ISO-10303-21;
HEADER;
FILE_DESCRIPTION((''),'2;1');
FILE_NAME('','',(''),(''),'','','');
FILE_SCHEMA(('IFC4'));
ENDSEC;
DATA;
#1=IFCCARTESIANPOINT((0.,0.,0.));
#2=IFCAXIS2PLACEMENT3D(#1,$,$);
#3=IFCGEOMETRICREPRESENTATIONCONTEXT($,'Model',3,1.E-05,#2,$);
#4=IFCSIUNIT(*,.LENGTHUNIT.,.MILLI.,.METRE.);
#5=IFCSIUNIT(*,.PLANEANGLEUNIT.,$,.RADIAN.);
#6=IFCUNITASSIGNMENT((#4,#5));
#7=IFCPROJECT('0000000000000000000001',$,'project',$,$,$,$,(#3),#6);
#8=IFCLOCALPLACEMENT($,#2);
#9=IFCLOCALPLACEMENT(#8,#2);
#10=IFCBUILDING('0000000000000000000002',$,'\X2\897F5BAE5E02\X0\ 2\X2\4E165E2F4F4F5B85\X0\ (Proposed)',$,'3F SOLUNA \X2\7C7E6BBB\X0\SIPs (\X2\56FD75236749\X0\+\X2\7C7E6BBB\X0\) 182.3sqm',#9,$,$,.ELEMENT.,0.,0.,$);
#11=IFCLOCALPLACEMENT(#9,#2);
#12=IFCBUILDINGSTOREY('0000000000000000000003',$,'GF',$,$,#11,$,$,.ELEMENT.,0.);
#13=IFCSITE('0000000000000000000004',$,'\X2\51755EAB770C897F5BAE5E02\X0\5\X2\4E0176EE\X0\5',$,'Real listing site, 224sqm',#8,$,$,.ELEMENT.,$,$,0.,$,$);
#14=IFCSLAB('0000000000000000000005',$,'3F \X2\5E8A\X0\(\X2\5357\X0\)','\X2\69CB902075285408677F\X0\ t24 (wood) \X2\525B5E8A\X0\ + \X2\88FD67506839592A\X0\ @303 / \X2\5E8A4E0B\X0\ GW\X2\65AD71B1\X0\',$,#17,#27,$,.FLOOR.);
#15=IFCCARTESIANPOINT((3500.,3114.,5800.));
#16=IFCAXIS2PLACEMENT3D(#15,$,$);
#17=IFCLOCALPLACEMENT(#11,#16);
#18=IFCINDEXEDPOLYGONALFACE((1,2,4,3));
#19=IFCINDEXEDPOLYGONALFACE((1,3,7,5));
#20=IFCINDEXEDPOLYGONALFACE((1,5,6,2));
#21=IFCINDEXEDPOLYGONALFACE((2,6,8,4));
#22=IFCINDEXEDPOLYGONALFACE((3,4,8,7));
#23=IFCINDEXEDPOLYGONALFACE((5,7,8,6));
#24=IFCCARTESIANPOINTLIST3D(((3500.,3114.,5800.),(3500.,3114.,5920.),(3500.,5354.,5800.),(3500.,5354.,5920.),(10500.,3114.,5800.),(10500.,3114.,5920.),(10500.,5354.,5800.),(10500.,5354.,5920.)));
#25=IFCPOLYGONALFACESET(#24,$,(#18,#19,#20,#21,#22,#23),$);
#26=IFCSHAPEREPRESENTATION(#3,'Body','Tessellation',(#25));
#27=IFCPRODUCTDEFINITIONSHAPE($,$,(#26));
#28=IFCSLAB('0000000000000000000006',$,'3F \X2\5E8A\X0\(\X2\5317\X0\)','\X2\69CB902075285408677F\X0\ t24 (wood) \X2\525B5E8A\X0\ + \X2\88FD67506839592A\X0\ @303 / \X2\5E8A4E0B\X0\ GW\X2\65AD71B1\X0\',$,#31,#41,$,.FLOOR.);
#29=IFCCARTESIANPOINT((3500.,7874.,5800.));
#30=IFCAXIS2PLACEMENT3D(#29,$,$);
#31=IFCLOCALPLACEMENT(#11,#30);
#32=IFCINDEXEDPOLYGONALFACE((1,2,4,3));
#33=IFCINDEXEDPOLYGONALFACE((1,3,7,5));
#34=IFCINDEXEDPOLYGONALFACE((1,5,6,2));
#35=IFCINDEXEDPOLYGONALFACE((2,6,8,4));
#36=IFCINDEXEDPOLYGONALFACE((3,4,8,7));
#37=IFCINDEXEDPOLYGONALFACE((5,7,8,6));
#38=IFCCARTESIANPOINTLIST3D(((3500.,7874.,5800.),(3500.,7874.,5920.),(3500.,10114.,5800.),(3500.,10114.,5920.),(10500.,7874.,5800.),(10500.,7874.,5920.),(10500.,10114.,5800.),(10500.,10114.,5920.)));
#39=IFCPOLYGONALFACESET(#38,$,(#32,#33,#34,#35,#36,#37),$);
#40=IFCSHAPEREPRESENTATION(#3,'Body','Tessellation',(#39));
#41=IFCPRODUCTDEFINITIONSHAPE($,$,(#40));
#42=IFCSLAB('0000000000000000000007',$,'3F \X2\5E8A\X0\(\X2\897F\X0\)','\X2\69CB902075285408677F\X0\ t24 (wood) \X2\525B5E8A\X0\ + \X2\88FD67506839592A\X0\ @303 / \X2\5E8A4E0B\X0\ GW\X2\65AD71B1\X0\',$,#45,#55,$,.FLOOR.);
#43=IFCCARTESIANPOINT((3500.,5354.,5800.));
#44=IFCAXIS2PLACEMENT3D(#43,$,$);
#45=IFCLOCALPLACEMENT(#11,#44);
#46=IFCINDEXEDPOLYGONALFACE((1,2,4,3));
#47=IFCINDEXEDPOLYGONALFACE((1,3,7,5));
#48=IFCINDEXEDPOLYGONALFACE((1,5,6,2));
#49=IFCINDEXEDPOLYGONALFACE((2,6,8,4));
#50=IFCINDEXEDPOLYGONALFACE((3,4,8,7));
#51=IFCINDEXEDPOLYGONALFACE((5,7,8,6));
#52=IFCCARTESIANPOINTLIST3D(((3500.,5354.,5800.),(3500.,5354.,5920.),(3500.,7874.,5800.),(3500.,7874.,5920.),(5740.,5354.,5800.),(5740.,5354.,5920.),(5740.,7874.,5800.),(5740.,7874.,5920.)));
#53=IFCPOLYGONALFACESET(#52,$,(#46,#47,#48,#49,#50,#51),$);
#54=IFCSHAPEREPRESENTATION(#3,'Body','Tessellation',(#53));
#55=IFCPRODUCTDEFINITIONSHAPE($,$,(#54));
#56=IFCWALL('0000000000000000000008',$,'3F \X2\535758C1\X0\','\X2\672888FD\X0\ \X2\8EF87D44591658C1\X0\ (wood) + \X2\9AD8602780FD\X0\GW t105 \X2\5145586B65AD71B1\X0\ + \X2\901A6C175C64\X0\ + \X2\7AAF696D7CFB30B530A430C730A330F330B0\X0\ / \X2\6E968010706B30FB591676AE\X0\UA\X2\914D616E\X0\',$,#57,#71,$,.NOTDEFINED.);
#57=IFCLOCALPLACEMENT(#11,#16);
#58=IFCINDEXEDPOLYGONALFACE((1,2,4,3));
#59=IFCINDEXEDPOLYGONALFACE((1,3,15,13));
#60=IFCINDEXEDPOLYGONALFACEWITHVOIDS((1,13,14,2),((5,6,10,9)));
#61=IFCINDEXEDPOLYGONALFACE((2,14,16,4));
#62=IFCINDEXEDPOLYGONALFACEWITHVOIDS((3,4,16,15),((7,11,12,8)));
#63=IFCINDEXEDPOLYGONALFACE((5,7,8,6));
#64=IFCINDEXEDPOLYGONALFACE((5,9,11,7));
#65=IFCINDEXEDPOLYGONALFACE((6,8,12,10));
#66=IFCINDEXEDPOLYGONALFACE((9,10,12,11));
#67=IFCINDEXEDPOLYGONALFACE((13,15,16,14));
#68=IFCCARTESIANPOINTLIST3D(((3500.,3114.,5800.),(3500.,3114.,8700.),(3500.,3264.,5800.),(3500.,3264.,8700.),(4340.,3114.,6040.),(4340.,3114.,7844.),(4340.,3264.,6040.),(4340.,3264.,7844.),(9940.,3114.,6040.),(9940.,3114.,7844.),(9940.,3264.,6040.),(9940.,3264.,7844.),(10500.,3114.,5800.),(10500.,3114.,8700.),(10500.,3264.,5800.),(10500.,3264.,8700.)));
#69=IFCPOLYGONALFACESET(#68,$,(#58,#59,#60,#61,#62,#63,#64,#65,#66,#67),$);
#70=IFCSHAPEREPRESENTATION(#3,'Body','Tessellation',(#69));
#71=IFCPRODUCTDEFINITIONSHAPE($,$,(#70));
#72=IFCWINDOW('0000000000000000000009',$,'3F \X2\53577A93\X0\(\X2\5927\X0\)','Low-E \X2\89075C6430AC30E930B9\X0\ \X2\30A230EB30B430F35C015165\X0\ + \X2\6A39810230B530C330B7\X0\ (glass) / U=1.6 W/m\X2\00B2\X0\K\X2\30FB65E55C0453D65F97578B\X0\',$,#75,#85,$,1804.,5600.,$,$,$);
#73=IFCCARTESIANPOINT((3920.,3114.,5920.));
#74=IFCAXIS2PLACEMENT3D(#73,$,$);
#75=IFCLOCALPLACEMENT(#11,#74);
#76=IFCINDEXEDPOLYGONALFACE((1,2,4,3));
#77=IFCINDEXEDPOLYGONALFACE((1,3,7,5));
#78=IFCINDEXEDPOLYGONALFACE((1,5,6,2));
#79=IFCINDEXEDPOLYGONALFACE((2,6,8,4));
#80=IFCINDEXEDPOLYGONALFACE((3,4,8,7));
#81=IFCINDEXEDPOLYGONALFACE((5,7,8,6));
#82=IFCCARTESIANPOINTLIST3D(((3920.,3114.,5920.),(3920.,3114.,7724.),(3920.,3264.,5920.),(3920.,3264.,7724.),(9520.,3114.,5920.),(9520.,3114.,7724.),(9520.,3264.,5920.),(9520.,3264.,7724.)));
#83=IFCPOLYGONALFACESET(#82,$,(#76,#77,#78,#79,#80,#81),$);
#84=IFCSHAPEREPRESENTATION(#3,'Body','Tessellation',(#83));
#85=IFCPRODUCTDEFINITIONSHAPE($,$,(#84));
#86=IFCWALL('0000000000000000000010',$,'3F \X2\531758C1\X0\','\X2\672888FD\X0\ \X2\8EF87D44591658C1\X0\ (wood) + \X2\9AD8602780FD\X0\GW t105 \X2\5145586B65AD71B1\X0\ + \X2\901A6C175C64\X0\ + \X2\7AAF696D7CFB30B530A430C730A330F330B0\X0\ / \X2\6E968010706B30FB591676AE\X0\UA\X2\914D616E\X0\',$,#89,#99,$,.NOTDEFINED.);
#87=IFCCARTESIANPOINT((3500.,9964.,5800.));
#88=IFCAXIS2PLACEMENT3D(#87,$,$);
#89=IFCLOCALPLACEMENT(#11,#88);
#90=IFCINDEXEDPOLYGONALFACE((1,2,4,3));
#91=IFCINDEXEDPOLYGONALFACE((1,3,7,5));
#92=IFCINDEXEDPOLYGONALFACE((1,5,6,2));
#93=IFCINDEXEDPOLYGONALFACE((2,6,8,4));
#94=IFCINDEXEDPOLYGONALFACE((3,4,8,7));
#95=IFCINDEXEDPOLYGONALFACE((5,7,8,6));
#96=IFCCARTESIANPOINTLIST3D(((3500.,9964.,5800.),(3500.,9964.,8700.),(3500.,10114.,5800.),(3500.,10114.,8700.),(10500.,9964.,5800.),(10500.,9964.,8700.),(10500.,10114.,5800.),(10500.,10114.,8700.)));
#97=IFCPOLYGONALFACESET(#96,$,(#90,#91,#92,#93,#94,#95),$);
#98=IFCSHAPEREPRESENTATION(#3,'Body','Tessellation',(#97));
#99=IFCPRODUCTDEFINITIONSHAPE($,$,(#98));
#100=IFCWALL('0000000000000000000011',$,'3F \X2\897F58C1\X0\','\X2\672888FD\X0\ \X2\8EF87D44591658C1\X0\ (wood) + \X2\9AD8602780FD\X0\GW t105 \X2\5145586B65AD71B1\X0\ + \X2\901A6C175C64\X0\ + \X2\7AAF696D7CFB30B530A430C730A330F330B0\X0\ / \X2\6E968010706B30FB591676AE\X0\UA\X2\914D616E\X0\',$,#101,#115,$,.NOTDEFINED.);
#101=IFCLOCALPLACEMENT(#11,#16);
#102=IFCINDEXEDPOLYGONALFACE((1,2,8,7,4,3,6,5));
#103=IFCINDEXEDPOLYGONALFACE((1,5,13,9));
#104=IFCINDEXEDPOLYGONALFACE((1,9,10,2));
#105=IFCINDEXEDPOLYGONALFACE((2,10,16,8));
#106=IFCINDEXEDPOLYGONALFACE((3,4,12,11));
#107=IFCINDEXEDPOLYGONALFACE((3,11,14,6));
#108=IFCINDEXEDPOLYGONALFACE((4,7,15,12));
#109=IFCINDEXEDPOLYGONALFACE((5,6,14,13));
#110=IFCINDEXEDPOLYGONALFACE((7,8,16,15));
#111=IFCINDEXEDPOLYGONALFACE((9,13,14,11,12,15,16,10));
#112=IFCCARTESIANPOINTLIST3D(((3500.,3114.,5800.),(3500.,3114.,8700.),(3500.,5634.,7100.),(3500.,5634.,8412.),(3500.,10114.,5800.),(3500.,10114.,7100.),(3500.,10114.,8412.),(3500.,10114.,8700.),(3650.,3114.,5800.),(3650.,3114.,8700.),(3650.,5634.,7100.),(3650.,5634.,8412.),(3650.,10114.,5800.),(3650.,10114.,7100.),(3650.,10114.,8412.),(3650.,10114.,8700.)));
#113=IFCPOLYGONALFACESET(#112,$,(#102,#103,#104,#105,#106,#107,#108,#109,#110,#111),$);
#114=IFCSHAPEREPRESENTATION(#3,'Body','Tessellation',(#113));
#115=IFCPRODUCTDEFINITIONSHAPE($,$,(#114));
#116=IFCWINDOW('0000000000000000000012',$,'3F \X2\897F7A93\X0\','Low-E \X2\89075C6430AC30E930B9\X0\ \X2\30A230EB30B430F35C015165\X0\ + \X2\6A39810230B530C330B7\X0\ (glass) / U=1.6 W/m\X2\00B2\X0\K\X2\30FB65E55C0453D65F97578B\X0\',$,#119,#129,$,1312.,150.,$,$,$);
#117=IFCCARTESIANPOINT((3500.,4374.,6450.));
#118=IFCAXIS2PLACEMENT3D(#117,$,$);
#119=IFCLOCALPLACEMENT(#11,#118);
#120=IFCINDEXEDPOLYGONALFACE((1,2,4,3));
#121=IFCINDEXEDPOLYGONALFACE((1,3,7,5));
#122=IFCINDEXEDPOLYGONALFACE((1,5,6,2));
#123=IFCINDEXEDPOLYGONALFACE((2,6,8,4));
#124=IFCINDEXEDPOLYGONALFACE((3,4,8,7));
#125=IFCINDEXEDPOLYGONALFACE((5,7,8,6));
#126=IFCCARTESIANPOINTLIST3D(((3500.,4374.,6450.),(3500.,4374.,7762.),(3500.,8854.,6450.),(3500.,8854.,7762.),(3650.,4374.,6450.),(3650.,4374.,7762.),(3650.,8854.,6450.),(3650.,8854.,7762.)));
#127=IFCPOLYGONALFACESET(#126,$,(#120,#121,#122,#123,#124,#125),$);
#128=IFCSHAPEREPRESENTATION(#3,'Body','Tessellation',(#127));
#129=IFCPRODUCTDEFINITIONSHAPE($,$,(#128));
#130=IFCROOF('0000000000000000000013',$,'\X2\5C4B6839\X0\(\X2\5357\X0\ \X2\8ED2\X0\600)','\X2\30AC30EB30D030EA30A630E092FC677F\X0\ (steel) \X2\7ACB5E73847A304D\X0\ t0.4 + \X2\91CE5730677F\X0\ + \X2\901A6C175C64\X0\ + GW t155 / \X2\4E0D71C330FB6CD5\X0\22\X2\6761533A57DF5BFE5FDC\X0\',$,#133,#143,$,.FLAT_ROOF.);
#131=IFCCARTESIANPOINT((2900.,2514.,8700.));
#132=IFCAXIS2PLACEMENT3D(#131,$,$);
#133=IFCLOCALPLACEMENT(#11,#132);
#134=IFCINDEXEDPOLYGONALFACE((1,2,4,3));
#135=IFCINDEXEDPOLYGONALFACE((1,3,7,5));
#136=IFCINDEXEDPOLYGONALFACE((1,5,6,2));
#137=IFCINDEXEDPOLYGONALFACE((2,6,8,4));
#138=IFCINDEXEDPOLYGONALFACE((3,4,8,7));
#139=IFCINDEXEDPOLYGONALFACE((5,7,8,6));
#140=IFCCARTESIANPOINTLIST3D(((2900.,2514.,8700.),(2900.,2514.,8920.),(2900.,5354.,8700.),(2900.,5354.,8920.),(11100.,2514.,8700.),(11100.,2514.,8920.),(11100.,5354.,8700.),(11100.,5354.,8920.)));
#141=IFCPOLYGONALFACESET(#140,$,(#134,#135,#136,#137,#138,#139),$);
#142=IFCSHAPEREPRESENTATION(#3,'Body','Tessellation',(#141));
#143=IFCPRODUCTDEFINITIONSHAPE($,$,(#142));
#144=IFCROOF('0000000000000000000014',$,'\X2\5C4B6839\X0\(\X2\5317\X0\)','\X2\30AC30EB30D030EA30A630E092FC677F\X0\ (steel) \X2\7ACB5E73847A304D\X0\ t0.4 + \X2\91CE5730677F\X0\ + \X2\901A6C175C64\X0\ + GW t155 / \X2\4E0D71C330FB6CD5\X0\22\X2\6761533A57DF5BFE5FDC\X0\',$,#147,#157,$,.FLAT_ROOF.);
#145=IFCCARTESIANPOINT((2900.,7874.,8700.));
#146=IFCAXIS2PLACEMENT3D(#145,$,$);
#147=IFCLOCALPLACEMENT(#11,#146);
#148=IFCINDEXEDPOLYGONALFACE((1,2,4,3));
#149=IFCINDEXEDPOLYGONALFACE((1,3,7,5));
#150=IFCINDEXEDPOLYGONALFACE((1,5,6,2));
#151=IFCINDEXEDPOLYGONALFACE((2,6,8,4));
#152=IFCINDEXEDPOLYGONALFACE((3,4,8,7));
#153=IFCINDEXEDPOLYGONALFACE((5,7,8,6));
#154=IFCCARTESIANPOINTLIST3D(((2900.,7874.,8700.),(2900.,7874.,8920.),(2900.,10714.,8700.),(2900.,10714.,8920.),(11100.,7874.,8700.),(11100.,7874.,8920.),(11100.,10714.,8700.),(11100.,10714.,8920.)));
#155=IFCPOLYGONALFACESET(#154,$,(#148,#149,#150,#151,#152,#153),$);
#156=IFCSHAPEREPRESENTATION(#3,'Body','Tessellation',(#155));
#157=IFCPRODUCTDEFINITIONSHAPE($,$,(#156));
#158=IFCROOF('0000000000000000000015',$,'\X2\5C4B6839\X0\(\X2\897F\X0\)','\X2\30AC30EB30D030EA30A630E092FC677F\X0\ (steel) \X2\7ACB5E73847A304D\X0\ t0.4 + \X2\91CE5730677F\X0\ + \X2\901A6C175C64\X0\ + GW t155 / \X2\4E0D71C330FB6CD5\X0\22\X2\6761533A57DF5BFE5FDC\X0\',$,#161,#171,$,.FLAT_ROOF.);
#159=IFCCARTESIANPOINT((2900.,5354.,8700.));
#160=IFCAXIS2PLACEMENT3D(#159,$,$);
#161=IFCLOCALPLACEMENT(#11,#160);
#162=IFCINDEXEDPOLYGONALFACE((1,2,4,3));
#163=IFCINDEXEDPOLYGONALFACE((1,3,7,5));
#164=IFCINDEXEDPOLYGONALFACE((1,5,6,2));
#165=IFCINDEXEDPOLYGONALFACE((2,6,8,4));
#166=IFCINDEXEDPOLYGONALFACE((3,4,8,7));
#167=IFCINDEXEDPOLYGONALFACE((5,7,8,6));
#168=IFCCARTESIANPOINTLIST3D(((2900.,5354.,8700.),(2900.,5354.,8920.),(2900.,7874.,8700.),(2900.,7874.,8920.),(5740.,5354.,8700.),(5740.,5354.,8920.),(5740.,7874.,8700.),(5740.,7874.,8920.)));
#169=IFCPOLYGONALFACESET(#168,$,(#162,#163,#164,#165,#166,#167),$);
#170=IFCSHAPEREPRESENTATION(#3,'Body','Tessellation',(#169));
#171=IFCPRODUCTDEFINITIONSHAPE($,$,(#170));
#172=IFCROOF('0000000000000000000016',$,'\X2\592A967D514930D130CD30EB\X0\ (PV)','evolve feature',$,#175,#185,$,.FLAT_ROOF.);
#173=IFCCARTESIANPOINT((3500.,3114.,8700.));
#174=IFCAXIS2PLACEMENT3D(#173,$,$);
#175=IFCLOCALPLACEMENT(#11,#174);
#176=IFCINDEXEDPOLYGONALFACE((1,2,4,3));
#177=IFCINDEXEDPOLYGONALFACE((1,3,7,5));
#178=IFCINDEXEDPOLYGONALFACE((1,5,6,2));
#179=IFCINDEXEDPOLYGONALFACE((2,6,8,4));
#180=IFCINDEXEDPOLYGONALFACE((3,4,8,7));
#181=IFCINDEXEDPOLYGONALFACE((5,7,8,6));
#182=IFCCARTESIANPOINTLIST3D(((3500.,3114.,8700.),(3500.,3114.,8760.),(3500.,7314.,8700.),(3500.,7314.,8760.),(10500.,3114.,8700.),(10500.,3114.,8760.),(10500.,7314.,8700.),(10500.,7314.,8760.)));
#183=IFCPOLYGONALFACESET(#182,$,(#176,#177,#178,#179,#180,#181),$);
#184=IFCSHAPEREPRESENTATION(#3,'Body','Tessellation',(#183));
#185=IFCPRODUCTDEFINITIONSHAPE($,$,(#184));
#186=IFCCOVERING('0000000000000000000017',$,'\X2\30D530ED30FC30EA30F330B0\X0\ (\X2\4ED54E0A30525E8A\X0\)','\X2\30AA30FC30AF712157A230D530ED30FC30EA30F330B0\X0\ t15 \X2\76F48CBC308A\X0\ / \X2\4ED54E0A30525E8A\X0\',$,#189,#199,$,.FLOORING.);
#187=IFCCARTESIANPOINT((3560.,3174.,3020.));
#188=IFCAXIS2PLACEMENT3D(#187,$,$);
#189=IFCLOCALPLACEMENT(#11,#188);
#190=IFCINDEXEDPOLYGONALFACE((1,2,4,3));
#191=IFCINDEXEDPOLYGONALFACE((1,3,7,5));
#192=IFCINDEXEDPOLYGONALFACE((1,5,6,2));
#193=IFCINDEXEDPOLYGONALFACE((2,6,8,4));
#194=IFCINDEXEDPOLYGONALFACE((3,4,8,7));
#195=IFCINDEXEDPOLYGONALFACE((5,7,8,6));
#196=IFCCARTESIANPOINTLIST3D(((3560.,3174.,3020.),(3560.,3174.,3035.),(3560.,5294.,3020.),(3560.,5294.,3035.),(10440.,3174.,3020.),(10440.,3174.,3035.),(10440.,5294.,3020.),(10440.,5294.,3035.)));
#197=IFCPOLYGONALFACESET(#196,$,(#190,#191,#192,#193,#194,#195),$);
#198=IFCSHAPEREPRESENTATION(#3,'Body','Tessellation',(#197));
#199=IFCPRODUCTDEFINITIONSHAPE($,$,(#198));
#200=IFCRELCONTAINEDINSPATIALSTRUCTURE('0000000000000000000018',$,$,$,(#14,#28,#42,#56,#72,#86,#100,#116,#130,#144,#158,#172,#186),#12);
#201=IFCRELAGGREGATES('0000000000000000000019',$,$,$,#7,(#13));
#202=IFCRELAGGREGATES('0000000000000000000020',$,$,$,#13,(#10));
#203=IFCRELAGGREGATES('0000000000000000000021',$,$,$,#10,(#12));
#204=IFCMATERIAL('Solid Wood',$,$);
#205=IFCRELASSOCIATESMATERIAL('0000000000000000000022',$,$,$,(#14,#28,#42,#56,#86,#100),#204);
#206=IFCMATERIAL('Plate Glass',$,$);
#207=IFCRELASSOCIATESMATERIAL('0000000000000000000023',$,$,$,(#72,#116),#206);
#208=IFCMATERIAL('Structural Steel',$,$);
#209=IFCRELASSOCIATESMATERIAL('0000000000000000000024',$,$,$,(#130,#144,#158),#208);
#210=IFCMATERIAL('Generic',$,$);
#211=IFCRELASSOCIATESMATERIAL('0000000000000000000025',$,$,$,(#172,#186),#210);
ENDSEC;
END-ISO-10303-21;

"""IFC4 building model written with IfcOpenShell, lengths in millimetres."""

from ifc_helpers import new_model, si_unit, frame, frame_2d, origin, place, context, project, spatial, rectangle, extrude, material, element, fill, save


model = new_model("IFC4")

# Units and contexts
model_context = context("Model", 3, precision=1e-05, world=origin())
ifc_project = project(units=[si_unit("LENGTHUNIT", "METRE", prefix="MILLI"), si_unit("PLANEANGLEUNIT", "RADIAN")], contexts=[model_context])

# Site, building, storey
site_placement = place(None, origin())
site = spatial("IfcSite", under=ifc_project, at=site_placement, Name="兵庫県西宮市5丁目5", ObjectType="Real listing site, 224sqm", CompositionType="ELEMENT", RefElevation=0.0)
building_placement = place(site_placement, origin())
building = spatial("IfcBuilding", under=site, at=building_placement, Name="西宮市 2世帯住宅 (Proposed)", ObjectType="3F SOLUNA 籾殻SIPs (国産杉+籾殻) 182.3sqm", CompositionType="ELEMENT", ElevationOfRefHeight=0.0, ElevationOfTerrain=0.0)
storey_placement = place(building_placement, origin())
storey = spatial("IfcBuildingStorey", under=building, at=storey_placement, Name="GF", CompositionType="ELEMENT", Elevation=0.0)

# Slabs
ifc_material_1 = material(Name="Solid Wood")
slab_1_placement = place(storey_placement, frame((3500.0, 3114.0, 5800.0)))
element("IfcSlab", 1, at=slab_1_placement, inside=storey, material=ifc_material_1, Name="3F 床(南)", Description="構造用合板 t24 (wood) 剛床 + 製材根太 @303 / 床下 GW断熱", PredefinedType="FLOOR", context=model_context, shape_type="SweptSolid", body=[
    extrude(rectangle(XDim=7000.0, YDim=2240.0, at=frame_2d((3500.0, 1120.0))), frame((3500.0, 3114.0, 5800.0)), (0.0, 0.0, 1.0), 120.0),
])
slab_2_placement = place(storey_placement, frame((3500.0, 7874.0, 5800.0)))
element("IfcSlab", 2, at=slab_2_placement, inside=storey, material=ifc_material_1, Name="3F 床(北)", Description="構造用合板 t24 (wood) 剛床 + 製材根太 @303 / 床下 GW断熱", PredefinedType="FLOOR", context=model_context, shape_type="SweptSolid", body=[
    extrude(rectangle(XDim=7000.0, YDim=2240.0, at=frame_2d((3500.0, 1120.0))), frame((3500.0, 7874.0, 5800.0)), (0.0, 0.0, 1.0), 120.0),
])
slab_3_placement = place(storey_placement, frame((3500.0, 5354.0, 5800.0)))
element("IfcSlab", 3, at=slab_3_placement, inside=storey, material=ifc_material_1, Name="3F 床(西)", Description="構造用合板 t24 (wood) 剛床 + 製材根太 @303 / 床下 GW断熱", PredefinedType="FLOOR", context=model_context, shape_type="SweptSolid", body=[
    extrude(rectangle(XDim=2240.0, YDim=2520.0, at=frame_2d((1120.0, 1260.0))), frame((3500.0, 5354.0, 5800.0)), (0.0, 0.0, 1.0), 120.0),
])

# Wall, opening, window
wall_1_placement = place(storey_placement, frame((3500.0, 3114.0, 5800.0)))
wall_1 = element("IfcWall", 4, at=wall_1_placement, inside=storey, material=ifc_material_1, Name="3F 南壁", Description="木製 軸組外壁 (wood) + 高性能GW t105 充填断熱 + 通気層 + 窯業系サイディング / 準耐火・外皮UA配慮", PredefinedType="NOTDEFINED", context=model_context, shape_type="SweptSolid", body=[
    extrude(rectangle(XDim=7000.0, YDim=150.0, at=frame_2d((3500.0, 75.0))), frame((3500.0, 3114.0, 5800.0)), (0.0, 0.0, 1.0), 2900.0),
])
opening_1_placement = place(storey_placement, frame((3920.0, 3114.0, 5920.0)))
opening_1 = element("IfcOpeningElement", 5, at=opening_1_placement, cuts=wall_1, PredefinedType="NOTDEFINED", context=model_context, shape_type="SweptSolid", body=[
    extrude(rectangle(XDim=5600.0, YDim=150.0, at=frame_2d((2800.0, 75.0))), frame((3920.0, 3114.0, 5920.0)), (0.0, 0.0, 1.0), 1804.0),
])
ifc_material_2 = material(Name="Plate Glass")
window_1_placement = place(storey_placement, frame((3920.0, 3114.0, 5920.0)))
window_1 = element("IfcWindow", 6, at=window_1_placement, inside=storey, material=ifc_material_2, Name="3F 南窓(大)", Description="Low-E 複層ガラス アルゴン封入 + 樹脂サッシ (glass) / U=1.6 W/m²K・日射取得型", OverallHeight=1804.0, OverallWidth=5600.0, context=model_context, shape_type="SweptSolid", body=[
    extrude(rectangle(XDim=5600.0, YDim=150.0, at=frame_2d((2800.0, 75.0))), frame((3920.0, 3114.0, 5920.0)), (0.0, 0.0, 1.0), 1804.0),
])
fill(opening_1, window_1)

# Wall
wall_2_placement = place(storey_placement, frame((3500.0, 9964.0, 5800.0)))
element("IfcWall", 7, at=wall_2_placement, inside=storey, material=ifc_material_1, Name="3F 北壁", Description="木製 軸組外壁 (wood) + 高性能GW t105 充填断熱 + 通気層 + 窯業系サイディング / 準耐火・外皮UA配慮", PredefinedType="NOTDEFINED", context=model_context, shape_type="SweptSolid", body=[
    extrude(rectangle(XDim=7000.0, YDim=150.0, at=frame_2d((3500.0, 75.0))), frame((3500.0, 9964.0, 5800.0)), (0.0, 0.0, 1.0), 2900.0),
])

# Wall, opening, window
wall_3_placement = place(storey_placement, frame((3500.0, 3114.0, 5800.0)))
wall_3 = element("IfcWall", 8, at=wall_3_placement, inside=storey, material=ifc_material_1, Name="3F 西壁", Description="木製 軸組外壁 (wood) + 高性能GW t105 充填断熱 + 通気層 + 窯業系サイディング / 準耐火・外皮UA配慮", PredefinedType="NOTDEFINED", context=model_context, shape_type="SweptSolid", body=[
    extrude(rectangle(XDim=150.0, YDim=7000.0, at=frame_2d((75.0, 3500.0))), frame((3500.0, 3114.0, 5800.0)), (0.0, 0.0, 1.0), 2900.0),
])
opening_2_placement = place(storey_placement, frame((3500.0, 4374.0, 6450.0)))
opening_2 = element("IfcOpeningElement", 9, at=opening_2_placement, cuts=wall_3, PredefinedType="NOTDEFINED", context=model_context, shape_type="SweptSolid", body=[
    extrude(rectangle(XDim=150.0, YDim=4480.0, at=frame_2d((75.0, 2240.0))), frame((3500.0, 4374.0, 6450.0)), (0.0, 0.0, 1.0), 1312.0),
])
window_2_placement = place(storey_placement, frame((3500.0, 4374.0, 6450.0)))
window_2 = element("IfcWindow", 10, at=window_2_placement, inside=storey, material=ifc_material_2, Name="3F 西窓", Description="Low-E 複層ガラス アルゴン封入 + 樹脂サッシ (glass) / U=1.6 W/m²K・日射取得型", OverallHeight=1312.0, OverallWidth=150.0, context=model_context, shape_type="SweptSolid", body=[
    extrude(rectangle(XDim=150.0, YDim=4480.0, at=frame_2d((75.0, 2240.0))), frame((3500.0, 4374.0, 6450.0)), (0.0, 0.0, 1.0), 1312.0),
])
fill(opening_2, window_2)

# Roofs
ifc_material_3 = material(Name="Structural Steel")
roof_1_placement = place(storey_placement, frame((2900.0, 2514.0, 8700.0)))
element("IfcRoof", 11, at=roof_1_placement, inside=storey, material=ifc_material_3, Name="屋根(南 軒600)", Description="ガルバリウム鋼板 (steel) 立平葺き t0.4 + 野地板 + 通気層 + GW t155 / 不燃・法22条区域対応", PredefinedType="FLAT_ROOF", context=model_context, shape_type="SweptSolid", body=[
    extrude(rectangle(XDim=8200.0, YDim=2840.0, at=frame_2d((4100.0, 1420.0))), frame((2900.0, 2514.0, 8700.0)), (0.0, 0.0, 1.0), 220.0),
])
roof_2_placement = place(storey_placement, frame((2900.0, 7874.0, 8700.0)))
element("IfcRoof", 12, at=roof_2_placement, inside=storey, material=ifc_material_3, Name="屋根(北)", Description="ガルバリウム鋼板 (steel) 立平葺き t0.4 + 野地板 + 通気層 + GW t155 / 不燃・法22条区域対応", PredefinedType="FLAT_ROOF", context=model_context, shape_type="SweptSolid", body=[
    extrude(rectangle(XDim=8200.0, YDim=2840.0, at=frame_2d((4100.0, 1420.0))), frame((2900.0, 7874.0, 8700.0)), (0.0, 0.0, 1.0), 220.0),
])
roof_3_placement = place(storey_placement, frame((2900.0, 5354.0, 8700.0)))
element("IfcRoof", 13, at=roof_3_placement, inside=storey, material=ifc_material_3, Name="屋根(西)", Description="ガルバリウム鋼板 (steel) 立平葺き t0.4 + 野地板 + 通気層 + GW t155 / 不燃・法22条区域対応", PredefinedType="FLAT_ROOF", context=model_context, shape_type="SweptSolid", body=[
    extrude(rectangle(XDim=2840.0, YDim=2520.0, at=frame_2d((1420.0, 1260.0))), frame((2900.0, 5354.0, 8700.0)), (0.0, 0.0, 1.0), 220.0),
])
ifc_material_4 = material(Name="Generic")
roof_4_placement = place(storey_placement, frame((3500.0, 3114.0, 8700.0)))
element("IfcRoof", 14, at=roof_4_placement, inside=storey, material=ifc_material_4, Name="太陽光パネル (PV)", Description="evolve feature", PredefinedType="FLAT_ROOF", context=model_context, shape_type="SweptSolid", body=[
    extrude(rectangle(XDim=7000.0, YDim=4200.0, at=frame_2d((3500.0, 2100.0))), frame((3500.0, 3114.0, 8700.0)), (0.0, 0.0, 1.0), 60.0),
])

# Covering
covering_1_placement = place(storey_placement, frame((3560.0, 3174.0, 3020.0)))
element("IfcCovering", 15, at=covering_1_placement, inside=storey, material=ifc_material_4, Name="フローリング (仕上げ床)", Description="オーク無垢フローリング t15 直貼り / 仕上げ床", PredefinedType="FLOORING", context=model_context, shape_type="SweptSolid", body=[
    extrude(rectangle(XDim=6880.0, YDim=2120.0, at=frame_2d((3440.0, 1060.0))), frame((3560.0, 3174.0, 3020.0)), (0.0, 0.0, 1.0), 15.0),
])

save(model, "model.ifc")
